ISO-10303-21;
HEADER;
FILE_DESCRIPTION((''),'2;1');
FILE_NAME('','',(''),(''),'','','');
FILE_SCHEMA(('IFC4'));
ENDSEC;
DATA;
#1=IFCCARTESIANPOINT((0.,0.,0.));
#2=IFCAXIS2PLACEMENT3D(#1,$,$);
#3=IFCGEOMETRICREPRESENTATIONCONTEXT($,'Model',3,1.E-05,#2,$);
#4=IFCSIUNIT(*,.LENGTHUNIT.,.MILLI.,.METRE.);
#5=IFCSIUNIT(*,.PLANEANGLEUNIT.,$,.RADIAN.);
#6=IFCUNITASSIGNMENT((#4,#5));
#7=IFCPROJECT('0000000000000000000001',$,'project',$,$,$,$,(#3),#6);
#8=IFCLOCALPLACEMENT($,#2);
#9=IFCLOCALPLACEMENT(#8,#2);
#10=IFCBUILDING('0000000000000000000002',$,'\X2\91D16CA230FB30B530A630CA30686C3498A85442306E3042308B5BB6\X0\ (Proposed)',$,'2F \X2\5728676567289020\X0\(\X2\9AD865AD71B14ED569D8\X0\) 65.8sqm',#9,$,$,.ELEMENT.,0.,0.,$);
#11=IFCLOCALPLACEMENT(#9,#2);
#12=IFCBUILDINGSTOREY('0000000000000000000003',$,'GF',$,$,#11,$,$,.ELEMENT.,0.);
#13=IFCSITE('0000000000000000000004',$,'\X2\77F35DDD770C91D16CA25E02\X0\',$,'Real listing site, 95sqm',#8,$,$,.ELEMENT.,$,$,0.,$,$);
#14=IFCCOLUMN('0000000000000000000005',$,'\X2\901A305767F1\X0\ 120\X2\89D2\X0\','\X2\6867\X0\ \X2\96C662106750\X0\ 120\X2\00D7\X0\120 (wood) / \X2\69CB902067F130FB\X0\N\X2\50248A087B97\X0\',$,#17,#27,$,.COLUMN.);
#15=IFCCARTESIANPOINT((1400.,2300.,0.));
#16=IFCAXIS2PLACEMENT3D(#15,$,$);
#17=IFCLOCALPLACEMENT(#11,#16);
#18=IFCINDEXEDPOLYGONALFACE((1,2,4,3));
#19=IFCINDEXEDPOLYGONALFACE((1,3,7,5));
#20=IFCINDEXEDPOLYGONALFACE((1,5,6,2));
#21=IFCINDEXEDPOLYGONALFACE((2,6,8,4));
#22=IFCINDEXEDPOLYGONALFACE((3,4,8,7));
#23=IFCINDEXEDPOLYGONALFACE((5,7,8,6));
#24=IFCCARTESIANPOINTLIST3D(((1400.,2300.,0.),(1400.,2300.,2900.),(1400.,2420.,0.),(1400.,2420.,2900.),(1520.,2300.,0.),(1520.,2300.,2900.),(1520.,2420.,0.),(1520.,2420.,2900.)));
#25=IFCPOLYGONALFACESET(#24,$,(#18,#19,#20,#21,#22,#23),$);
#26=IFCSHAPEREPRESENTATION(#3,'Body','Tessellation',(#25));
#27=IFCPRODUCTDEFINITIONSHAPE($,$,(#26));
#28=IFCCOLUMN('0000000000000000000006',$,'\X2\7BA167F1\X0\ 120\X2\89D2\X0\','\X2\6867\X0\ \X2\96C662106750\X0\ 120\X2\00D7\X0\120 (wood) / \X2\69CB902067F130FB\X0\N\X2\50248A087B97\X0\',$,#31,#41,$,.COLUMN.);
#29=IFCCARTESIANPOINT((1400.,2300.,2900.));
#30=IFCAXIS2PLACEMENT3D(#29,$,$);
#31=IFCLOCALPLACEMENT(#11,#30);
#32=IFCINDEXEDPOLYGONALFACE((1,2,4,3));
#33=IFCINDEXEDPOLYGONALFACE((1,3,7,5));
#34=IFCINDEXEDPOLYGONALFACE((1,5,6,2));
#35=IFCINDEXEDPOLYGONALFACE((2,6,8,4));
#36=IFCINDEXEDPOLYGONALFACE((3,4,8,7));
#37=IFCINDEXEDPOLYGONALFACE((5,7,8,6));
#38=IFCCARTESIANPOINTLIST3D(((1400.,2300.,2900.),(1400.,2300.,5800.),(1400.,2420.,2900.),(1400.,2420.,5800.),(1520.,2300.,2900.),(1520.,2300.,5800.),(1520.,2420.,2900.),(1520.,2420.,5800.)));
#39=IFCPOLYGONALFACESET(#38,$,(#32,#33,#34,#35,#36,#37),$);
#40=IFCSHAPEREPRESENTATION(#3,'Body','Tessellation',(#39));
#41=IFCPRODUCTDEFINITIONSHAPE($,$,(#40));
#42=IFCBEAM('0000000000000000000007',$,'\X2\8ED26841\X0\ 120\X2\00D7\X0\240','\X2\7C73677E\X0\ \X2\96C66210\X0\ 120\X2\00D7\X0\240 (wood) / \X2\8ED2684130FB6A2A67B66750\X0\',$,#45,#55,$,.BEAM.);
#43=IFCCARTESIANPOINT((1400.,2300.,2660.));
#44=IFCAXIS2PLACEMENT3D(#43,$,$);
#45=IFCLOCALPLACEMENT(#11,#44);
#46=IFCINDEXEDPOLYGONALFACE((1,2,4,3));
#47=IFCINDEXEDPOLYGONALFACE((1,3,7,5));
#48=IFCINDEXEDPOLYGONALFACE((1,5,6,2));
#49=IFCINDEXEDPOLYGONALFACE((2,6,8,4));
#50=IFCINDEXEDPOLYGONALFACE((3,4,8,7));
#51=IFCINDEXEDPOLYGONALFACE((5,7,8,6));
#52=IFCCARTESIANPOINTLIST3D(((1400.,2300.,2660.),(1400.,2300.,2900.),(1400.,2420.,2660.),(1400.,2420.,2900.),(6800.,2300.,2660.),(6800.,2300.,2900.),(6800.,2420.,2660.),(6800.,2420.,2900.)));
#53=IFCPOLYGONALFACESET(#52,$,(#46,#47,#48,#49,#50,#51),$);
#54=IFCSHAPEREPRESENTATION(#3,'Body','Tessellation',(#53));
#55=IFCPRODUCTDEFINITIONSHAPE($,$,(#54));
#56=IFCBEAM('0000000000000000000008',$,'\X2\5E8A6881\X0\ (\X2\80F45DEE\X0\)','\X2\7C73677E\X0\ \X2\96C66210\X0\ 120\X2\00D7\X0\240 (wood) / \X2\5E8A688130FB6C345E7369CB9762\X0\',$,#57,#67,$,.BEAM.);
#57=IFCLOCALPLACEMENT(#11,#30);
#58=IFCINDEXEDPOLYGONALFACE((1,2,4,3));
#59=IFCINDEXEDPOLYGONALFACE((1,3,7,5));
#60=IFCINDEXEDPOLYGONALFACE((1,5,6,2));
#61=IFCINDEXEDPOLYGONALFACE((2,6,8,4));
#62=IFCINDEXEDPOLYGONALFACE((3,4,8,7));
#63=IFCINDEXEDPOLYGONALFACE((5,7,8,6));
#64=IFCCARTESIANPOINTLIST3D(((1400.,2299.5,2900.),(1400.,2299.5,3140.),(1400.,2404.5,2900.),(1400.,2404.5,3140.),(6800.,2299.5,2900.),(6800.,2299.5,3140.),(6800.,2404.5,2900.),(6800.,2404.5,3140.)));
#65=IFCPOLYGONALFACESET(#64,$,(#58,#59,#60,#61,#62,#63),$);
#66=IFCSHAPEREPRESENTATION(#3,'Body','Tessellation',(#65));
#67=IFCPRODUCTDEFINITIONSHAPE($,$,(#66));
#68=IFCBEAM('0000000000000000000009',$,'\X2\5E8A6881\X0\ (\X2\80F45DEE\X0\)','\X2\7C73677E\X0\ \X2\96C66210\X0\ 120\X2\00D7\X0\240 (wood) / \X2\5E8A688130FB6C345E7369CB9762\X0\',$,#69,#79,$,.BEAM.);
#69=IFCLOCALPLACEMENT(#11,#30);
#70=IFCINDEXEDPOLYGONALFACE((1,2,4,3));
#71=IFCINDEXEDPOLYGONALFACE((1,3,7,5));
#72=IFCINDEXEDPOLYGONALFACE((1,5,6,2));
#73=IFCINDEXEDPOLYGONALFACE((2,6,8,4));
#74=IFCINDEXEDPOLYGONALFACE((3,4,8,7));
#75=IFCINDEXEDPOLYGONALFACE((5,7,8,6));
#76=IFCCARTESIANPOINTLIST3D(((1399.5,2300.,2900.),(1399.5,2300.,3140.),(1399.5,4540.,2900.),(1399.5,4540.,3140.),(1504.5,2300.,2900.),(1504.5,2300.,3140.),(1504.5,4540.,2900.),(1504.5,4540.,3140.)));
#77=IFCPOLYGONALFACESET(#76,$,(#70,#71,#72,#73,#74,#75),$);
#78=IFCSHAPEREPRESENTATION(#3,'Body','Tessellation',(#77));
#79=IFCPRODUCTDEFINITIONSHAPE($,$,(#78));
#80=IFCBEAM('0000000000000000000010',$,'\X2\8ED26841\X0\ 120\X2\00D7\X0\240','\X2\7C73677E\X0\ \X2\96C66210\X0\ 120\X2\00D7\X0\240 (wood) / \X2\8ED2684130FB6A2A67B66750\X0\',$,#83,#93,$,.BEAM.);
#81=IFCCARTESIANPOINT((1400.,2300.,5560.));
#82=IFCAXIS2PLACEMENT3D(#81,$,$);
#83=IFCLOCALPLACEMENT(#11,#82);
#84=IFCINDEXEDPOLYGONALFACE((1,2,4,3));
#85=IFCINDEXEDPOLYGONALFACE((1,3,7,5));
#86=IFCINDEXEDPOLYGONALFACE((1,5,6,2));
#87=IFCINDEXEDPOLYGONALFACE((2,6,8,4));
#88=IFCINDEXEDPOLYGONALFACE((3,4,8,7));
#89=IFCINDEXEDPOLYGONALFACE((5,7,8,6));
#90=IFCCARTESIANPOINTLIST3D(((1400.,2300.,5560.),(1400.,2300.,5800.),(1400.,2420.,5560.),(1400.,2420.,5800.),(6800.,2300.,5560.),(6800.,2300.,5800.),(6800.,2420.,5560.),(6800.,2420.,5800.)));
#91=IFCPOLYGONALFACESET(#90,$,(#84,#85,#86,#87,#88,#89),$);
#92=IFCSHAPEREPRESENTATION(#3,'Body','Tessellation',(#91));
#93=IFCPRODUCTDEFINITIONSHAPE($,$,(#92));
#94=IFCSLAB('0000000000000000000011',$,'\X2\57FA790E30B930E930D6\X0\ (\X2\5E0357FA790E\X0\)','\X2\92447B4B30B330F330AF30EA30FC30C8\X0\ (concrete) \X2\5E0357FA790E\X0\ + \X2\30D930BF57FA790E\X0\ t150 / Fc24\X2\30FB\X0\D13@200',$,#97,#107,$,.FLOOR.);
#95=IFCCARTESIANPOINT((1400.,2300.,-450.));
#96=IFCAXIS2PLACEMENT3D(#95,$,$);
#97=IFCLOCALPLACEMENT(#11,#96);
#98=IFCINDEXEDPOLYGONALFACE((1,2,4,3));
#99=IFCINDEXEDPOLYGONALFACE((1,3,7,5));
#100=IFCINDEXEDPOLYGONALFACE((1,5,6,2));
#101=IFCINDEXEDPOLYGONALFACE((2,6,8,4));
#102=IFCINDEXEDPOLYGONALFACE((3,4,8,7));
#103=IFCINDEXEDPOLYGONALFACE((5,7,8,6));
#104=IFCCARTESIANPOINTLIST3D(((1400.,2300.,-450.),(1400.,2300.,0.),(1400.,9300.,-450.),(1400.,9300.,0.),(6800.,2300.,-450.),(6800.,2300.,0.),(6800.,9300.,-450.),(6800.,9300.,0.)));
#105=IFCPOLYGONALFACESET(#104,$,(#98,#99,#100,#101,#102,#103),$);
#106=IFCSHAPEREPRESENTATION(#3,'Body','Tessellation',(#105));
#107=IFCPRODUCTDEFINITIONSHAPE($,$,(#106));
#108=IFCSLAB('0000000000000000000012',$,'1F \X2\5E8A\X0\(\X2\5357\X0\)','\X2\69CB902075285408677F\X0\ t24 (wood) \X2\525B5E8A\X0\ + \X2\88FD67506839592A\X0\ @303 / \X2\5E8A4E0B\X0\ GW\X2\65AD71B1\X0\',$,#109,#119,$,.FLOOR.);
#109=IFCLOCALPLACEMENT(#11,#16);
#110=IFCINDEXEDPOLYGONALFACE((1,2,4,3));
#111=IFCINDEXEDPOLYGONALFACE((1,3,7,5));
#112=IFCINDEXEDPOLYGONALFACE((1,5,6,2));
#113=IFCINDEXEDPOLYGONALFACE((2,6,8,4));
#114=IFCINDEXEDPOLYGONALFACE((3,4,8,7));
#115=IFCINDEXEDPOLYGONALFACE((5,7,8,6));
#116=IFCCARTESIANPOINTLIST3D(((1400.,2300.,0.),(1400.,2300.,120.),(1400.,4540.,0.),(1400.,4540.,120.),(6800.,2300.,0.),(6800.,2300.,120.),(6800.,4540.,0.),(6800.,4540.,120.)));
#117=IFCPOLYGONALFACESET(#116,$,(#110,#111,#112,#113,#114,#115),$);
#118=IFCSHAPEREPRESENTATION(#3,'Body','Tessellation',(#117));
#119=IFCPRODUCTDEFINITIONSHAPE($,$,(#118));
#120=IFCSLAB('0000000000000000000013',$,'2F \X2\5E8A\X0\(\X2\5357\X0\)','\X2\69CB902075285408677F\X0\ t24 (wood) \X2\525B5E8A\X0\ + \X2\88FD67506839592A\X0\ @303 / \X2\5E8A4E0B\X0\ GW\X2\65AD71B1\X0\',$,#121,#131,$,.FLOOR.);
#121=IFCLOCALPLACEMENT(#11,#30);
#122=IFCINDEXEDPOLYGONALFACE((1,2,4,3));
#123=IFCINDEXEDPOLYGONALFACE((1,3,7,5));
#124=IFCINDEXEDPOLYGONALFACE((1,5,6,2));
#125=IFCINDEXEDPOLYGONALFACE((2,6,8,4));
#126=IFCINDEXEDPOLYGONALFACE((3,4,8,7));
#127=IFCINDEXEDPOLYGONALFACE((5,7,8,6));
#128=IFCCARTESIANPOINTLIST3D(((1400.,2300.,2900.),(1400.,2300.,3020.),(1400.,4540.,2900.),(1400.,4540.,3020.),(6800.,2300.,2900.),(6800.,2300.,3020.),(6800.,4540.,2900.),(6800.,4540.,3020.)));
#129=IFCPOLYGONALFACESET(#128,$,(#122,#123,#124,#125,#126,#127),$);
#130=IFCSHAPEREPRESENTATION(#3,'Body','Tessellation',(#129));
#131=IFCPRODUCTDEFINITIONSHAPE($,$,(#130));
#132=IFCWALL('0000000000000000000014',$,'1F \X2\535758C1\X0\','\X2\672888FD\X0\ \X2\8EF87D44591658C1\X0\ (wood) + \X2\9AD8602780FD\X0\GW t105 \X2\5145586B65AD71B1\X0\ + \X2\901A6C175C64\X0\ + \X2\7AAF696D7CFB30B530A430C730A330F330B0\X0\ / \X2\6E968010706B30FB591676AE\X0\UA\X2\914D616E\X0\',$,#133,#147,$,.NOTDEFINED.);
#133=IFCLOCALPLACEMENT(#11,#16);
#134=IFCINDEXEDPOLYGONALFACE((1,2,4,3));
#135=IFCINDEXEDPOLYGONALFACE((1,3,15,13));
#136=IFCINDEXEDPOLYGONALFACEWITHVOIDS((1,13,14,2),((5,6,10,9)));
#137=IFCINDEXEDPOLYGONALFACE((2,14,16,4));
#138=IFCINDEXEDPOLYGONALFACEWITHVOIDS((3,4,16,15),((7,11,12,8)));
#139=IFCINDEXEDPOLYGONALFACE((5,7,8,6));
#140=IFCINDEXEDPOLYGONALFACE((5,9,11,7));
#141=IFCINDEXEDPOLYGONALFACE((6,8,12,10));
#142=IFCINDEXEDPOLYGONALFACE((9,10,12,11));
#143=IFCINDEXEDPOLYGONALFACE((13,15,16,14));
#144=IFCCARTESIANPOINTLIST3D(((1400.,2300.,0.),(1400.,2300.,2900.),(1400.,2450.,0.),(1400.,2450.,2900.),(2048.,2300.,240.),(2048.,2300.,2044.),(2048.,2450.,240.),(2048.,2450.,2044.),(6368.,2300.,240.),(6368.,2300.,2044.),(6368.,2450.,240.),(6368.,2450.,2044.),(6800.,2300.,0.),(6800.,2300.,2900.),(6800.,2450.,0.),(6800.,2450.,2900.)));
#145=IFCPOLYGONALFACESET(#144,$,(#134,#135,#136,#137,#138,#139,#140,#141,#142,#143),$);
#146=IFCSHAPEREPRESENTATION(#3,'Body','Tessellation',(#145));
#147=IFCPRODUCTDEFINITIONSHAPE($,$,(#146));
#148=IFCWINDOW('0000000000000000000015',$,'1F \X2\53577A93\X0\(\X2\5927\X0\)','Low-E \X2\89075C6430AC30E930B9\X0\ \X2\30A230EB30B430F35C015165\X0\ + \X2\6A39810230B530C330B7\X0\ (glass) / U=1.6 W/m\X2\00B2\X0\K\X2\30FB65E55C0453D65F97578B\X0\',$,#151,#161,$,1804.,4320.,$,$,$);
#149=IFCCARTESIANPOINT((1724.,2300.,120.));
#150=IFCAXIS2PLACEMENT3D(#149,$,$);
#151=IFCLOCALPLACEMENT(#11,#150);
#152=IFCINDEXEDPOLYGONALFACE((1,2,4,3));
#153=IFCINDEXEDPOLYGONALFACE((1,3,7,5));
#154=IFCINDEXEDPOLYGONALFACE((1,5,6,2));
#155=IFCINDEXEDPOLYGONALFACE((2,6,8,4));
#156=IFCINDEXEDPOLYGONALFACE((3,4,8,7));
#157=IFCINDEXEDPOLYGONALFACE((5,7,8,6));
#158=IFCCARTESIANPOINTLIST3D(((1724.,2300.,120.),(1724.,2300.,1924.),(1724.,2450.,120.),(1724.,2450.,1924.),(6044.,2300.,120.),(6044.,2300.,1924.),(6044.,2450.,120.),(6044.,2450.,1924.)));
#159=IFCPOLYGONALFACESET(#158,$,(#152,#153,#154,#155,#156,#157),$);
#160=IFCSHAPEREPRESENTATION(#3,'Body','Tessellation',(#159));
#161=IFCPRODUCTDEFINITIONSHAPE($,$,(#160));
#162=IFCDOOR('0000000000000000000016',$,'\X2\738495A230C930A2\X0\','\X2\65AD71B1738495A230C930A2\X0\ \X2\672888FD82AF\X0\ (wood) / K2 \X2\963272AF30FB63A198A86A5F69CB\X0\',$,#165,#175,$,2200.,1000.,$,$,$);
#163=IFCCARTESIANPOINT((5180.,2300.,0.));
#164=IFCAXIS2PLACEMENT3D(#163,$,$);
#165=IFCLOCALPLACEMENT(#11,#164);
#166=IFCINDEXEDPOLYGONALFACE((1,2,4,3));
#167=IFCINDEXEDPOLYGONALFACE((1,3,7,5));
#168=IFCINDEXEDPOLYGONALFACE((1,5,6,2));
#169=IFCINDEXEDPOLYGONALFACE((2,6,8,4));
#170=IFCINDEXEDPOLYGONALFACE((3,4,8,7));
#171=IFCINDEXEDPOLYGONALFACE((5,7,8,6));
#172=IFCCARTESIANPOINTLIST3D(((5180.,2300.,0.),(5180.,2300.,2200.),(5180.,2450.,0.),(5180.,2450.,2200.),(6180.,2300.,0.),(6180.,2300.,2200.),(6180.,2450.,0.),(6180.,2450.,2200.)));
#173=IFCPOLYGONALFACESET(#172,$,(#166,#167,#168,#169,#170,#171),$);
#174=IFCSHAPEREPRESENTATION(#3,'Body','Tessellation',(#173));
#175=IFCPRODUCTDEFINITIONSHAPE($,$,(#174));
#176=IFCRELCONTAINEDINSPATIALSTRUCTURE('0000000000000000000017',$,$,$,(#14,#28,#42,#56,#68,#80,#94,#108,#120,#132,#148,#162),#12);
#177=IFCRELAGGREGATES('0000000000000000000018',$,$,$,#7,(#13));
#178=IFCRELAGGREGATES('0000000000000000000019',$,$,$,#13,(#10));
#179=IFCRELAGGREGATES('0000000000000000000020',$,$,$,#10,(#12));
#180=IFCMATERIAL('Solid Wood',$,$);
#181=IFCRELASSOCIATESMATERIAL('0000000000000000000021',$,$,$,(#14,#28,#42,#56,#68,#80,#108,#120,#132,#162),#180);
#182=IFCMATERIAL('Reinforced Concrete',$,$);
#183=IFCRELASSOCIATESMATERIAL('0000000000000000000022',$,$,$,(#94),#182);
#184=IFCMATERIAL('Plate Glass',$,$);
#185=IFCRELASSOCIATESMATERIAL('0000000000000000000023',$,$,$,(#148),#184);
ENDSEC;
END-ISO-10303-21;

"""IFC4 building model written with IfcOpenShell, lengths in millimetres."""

from ifc_helpers import new_model, si_unit, frame, frame_2d, origin, place, context, project, spatial, rectangle, extrude, material, element, fill, save


model = new_model("IFC4")

# Units and contexts
model_context = context("Model", 3, precision=1e-05, world=origin())
ifc_project = project(units=[si_unit("LENGTHUNIT", "METRE", prefix="MILLI"), si_unit("PLANEANGLEUNIT", "RADIAN")], contexts=[model_context])

# Site, building, storey
site_placement = place(None, origin())
site = spatial("IfcSite", under=ifc_project, at=site_placement, Name="石川県金沢市", ObjectType="Real listing site, 95sqm", CompositionType="ELEMENT", RefElevation=0.0)
building_placement = place(site_placement, origin())
building = spatial("IfcBuilding", under=site, at=building_placement, Name="金沢・サウナと水風呂のある家 (Proposed)", ObjectType="2F 在来木造(高断熱仕様) 65.8sqm", CompositionType="ELEMENT", ElevationOfRefHeight=0.0, ElevationOfTerrain=0.0)
storey_placement = place(building_placement, origin())
storey = spatial("IfcBuildingStorey", under=building, at=storey_placement, Name="GF", CompositionType="ELEMENT", Elevation=0.0)

# Columns
ifc_material_1 = material(Name="Solid Wood")
column_1_placement = place(storey_placement, frame((1400.0, 2300.0, 0.0)))
element("IfcColumn", 1, at=column_1_placement, inside=storey, material=ifc_material_1, Name="通し柱 120角", Description="桧 集成材 120×120 (wood) / 構造柱・N値計算", PredefinedType="COLUMN", context=model_context, shape_type="SweptSolid", body=[
    extrude(rectangle(XDim=120.0, YDim=120.0, at=frame_2d((60.0, 60.0))), frame((1400.0, 2300.0, 0.0)), (0.0, 0.0, 1.0), 2900.0),
])
column_2_placement = place(storey_placement, frame((1400.0, 2300.0, 2900.0)))
element("IfcColumn", 2, at=column_2_placement, inside=storey, material=ifc_material_1, Name="管柱 120角", Description="桧 集成材 120×120 (wood) / 構造柱・N値計算", PredefinedType="COLUMN", context=model_context, shape_type="SweptSolid", body=[
    extrude(rectangle(XDim=120.0, YDim=120.0, at=frame_2d((60.0, 60.0))), frame((1400.0, 2300.0, 2900.0)), (0.0, 0.0, 1.0), 2900.0),
])

# Beams
beam_1_placement = place(storey_placement, frame((1400.0, 2300.0, 2660.0)))
element("IfcBeam", 3, at=beam_1_placement, inside=storey, material=ifc_material_1, Name="軒桁 120×240", Description="米松 集成 120×240 (wood) / 軒桁・横架材", PredefinedType="BEAM", context=model_context, shape_type="SweptSolid", body=[
    extrude(rectangle(XDim=5400.0, YDim=120.0, at=frame_2d((2700.0, 60.0))), frame((1400.0, 2300.0, 2660.0)), (0.0, 0.0, 1.0), 240.0),
])
beam_2_placement = place(storey_placement, frame((1400.0, 2300.0, 2900.0)))
element("IfcBeam", 4, at=beam_2_placement, inside=storey, material=ifc_material_1, Name="床梁 (胴差)", Description="米松 集成 120×240 (wood) / 床梁・水平構面", PredefinedType="BEAM", context=model_context, shape_type="SweptSolid", body=[
    extrude(rectangle(XDim=5400.0, YDim=105.0, at=frame_2d((2700.0, 52.0))), frame((1400.0, 2300.0, 2900.0)), (0.0, 0.0, 1.0), 240.0),
])
beam_3_placement = place(storey_placement, frame((1400.0, 2300.0, 2900.0)))
element("IfcBeam", 5, at=beam_3_placement, inside=storey, material=ifc_material_1, Name="床梁 (胴差)", Description="米松 集成 120×240 (wood) / 床梁・水平構面", PredefinedType="BEAM", context=model_context, shape_type="SweptSolid", body=[
    extrude(rectangle(XDim=105.0, YDim=2240.0, at=frame_2d((52.0, 1120.0))), frame((1400.0, 2300.0, 2900.0)), (0.0, 0.0, 1.0), 240.0),
])
beam_4_placement = place(storey_placement, frame((1400.0, 2300.0, 5560.0)))
element("IfcBeam", 6, at=beam_4_placement, inside=storey, material=ifc_material_1, Name="軒桁 120×240", Description="米松 集成 120×240 (wood) / 軒桁・横架材", PredefinedType="BEAM", context=model_context, shape_type="SweptSolid", body=[
    extrude(rectangle(XDim=5400.0, YDim=120.0, at=frame_2d((2700.0, 60.0))), frame((1400.0, 2300.0, 5560.0)), (0.0, 0.0, 1.0), 240.0),
])

# Slabs
ifc_material_2 = material(Name="Reinforced Concrete")
slab_1_placement = place(storey_placement, frame((1400.0, 2300.0, -450.0)))
element("IfcSlab", 7, at=slab_1_placement, inside=storey, material=ifc_material_2, Name="基礎スラブ (布基礎)", Description="鉄筋コンクリート (concrete) 布基礎 + ベタ基礎 t150 / Fc24・D13@200", PredefinedType="FLOOR", context=model_context, shape_type="SweptSolid", body=[
    extrude(rectangle(XDim=5400.0, YDim=7000.0, at=frame_2d((2700.0, 3500.0))), frame((1400.0, 2300.0, -450.0)), (0.0, 0.0, 1.0), 450.0),
])
slab_2_placement = place(storey_placement, frame((1400.0, 2300.0, 0.0)))
element("IfcSlab", 8, at=slab_2_placement, inside=storey, material=ifc_material_1, Name="1F 床(南)", Description="構造用合板 t24 (wood) 剛床 + 製材根太 @303 / 床下 GW断熱", PredefinedType="FLOOR", context=model_context, shape_type="SweptSolid", body=[
    extrude(rectangle(XDim=5400.0, YDim=2240.0, at=frame_2d((2700.0, 1120.0))), frame((1400.0, 2300.0, 0.0)), (0.0, 0.0, 1.0), 120.0),
])
slab_3_placement = place(storey_placement, frame((1400.0, 2300.0, 2900.0)))
element("IfcSlab", 9, at=slab_3_placement, inside=storey, material=ifc_material_1, Name="2F 床(南)", Description="構造用合板 t24 (wood) 剛床 + 製材根太 @303 / 床下 GW断熱", PredefinedType="FLOOR", context=model_context, shape_type="SweptSolid", body=[
    extrude(rectangle(XDim=5400.0, YDim=2240.0, at=frame_2d((2700.0, 1120.0))), frame((1400.0, 2300.0, 2900.0)), (0.0, 0.0, 1.0), 120.0),
])

# Wall, openings, window, door
wall_1_placement = place(storey_placement, frame((1400.0, 2300.0, 0.0)))
wall_1 = element("IfcWall", 10, at=wall_1_placement, inside=storey, material=ifc_material_1, Name="1F 南壁", Description="木製 軸組外壁 (wood) + 高性能GW t105 充填断熱 + 通気層 + 窯業系サイディング / 準耐火・外皮UA配慮", PredefinedType="NOTDEFINED", context=model_context, shape_type="SweptSolid", body=[
    extrude(rectangle(XDim=5400.0, YDim=150.0, at=frame_2d((2700.0, 75.0))), frame((1400.0, 2300.0, 0.0)), (0.0, 0.0, 1.0), 2900.0),
])
opening_1_placement = place(storey_placement, frame((1724.0, 2300.0, 120.0)))
opening_1 = element("IfcOpeningElement", 11, at=opening_1_placement, cuts=wall_1, PredefinedType="NOTDEFINED", context=model_context, shape_type="SweptSolid", body=[
    extrude(rectangle(XDim=4320.0, YDim=150.0, at=frame_2d((2160.0, 75.0))), frame((1724.0, 2300.0, 120.0)), (0.0, 0.0, 1.0), 1804.0),
])
opening_2_placement = place(storey_placement, frame((5180.0, 2300.0, 0.0)))
opening_2 = element("IfcOpeningElement", 12, at=opening_2_placement, cuts=wall_1, PredefinedType="NOTDEFINED", context=model_context, shape_type="SweptSolid", body=[
    extrude(rectangle(XDim=1000.0, YDim=150.0, at=frame_2d((500.0, 75.0))), frame((5180.0, 2300.0, 0.0)), (0.0, 0.0, 1.0), 2200.0),
])
ifc_material_3 = material(Name="Plate Glass")
window_1_placement = place(storey_placement, frame((1724.0, 2300.0, 120.0)))
window_1 = element("IfcWindow", 13, at=window_1_placement, inside=storey, material=ifc_material_3, Name="1F 南窓(大)", Description="Low-E 複層ガラス アルゴン封入 + 樹脂サッシ (glass) / U=1.6 W/m²K・日射取得型", OverallHeight=1804.0, OverallWidth=4320.0, context=model_context, shape_type="SweptSolid", body=[
    extrude(rectangle(XDim=4320.0, YDim=150.0, at=frame_2d((2160.0, 75.0))), frame((1724.0, 2300.0, 120.0)), (0.0, 0.0, 1.0), 1804.0),
])
fill(opening_1, window_1)
door_placement = place(storey_placement, frame((5180.0, 2300.0, 0.0)))
door = element("IfcDoor", 14, at=door_placement, inside=storey, material=ifc_material_1, Name="玄関ドア", Description="断熱玄関ドア 木製芯 (wood) / K2 防犯・採風機構", OverallHeight=2200.0, OverallWidth=1000.0, context=model_context, shape_type="SweptSolid", body=[
    extrude(rectangle(XDim=1000.0, YDim=150.0, at=frame_2d((500.0, 75.0))), frame((5180.0, 2300.0, 0.0)), (0.0, 0.0, 1.0), 2200.0),
])
fill(opening_2, door)

save(model, "model.ifc")
